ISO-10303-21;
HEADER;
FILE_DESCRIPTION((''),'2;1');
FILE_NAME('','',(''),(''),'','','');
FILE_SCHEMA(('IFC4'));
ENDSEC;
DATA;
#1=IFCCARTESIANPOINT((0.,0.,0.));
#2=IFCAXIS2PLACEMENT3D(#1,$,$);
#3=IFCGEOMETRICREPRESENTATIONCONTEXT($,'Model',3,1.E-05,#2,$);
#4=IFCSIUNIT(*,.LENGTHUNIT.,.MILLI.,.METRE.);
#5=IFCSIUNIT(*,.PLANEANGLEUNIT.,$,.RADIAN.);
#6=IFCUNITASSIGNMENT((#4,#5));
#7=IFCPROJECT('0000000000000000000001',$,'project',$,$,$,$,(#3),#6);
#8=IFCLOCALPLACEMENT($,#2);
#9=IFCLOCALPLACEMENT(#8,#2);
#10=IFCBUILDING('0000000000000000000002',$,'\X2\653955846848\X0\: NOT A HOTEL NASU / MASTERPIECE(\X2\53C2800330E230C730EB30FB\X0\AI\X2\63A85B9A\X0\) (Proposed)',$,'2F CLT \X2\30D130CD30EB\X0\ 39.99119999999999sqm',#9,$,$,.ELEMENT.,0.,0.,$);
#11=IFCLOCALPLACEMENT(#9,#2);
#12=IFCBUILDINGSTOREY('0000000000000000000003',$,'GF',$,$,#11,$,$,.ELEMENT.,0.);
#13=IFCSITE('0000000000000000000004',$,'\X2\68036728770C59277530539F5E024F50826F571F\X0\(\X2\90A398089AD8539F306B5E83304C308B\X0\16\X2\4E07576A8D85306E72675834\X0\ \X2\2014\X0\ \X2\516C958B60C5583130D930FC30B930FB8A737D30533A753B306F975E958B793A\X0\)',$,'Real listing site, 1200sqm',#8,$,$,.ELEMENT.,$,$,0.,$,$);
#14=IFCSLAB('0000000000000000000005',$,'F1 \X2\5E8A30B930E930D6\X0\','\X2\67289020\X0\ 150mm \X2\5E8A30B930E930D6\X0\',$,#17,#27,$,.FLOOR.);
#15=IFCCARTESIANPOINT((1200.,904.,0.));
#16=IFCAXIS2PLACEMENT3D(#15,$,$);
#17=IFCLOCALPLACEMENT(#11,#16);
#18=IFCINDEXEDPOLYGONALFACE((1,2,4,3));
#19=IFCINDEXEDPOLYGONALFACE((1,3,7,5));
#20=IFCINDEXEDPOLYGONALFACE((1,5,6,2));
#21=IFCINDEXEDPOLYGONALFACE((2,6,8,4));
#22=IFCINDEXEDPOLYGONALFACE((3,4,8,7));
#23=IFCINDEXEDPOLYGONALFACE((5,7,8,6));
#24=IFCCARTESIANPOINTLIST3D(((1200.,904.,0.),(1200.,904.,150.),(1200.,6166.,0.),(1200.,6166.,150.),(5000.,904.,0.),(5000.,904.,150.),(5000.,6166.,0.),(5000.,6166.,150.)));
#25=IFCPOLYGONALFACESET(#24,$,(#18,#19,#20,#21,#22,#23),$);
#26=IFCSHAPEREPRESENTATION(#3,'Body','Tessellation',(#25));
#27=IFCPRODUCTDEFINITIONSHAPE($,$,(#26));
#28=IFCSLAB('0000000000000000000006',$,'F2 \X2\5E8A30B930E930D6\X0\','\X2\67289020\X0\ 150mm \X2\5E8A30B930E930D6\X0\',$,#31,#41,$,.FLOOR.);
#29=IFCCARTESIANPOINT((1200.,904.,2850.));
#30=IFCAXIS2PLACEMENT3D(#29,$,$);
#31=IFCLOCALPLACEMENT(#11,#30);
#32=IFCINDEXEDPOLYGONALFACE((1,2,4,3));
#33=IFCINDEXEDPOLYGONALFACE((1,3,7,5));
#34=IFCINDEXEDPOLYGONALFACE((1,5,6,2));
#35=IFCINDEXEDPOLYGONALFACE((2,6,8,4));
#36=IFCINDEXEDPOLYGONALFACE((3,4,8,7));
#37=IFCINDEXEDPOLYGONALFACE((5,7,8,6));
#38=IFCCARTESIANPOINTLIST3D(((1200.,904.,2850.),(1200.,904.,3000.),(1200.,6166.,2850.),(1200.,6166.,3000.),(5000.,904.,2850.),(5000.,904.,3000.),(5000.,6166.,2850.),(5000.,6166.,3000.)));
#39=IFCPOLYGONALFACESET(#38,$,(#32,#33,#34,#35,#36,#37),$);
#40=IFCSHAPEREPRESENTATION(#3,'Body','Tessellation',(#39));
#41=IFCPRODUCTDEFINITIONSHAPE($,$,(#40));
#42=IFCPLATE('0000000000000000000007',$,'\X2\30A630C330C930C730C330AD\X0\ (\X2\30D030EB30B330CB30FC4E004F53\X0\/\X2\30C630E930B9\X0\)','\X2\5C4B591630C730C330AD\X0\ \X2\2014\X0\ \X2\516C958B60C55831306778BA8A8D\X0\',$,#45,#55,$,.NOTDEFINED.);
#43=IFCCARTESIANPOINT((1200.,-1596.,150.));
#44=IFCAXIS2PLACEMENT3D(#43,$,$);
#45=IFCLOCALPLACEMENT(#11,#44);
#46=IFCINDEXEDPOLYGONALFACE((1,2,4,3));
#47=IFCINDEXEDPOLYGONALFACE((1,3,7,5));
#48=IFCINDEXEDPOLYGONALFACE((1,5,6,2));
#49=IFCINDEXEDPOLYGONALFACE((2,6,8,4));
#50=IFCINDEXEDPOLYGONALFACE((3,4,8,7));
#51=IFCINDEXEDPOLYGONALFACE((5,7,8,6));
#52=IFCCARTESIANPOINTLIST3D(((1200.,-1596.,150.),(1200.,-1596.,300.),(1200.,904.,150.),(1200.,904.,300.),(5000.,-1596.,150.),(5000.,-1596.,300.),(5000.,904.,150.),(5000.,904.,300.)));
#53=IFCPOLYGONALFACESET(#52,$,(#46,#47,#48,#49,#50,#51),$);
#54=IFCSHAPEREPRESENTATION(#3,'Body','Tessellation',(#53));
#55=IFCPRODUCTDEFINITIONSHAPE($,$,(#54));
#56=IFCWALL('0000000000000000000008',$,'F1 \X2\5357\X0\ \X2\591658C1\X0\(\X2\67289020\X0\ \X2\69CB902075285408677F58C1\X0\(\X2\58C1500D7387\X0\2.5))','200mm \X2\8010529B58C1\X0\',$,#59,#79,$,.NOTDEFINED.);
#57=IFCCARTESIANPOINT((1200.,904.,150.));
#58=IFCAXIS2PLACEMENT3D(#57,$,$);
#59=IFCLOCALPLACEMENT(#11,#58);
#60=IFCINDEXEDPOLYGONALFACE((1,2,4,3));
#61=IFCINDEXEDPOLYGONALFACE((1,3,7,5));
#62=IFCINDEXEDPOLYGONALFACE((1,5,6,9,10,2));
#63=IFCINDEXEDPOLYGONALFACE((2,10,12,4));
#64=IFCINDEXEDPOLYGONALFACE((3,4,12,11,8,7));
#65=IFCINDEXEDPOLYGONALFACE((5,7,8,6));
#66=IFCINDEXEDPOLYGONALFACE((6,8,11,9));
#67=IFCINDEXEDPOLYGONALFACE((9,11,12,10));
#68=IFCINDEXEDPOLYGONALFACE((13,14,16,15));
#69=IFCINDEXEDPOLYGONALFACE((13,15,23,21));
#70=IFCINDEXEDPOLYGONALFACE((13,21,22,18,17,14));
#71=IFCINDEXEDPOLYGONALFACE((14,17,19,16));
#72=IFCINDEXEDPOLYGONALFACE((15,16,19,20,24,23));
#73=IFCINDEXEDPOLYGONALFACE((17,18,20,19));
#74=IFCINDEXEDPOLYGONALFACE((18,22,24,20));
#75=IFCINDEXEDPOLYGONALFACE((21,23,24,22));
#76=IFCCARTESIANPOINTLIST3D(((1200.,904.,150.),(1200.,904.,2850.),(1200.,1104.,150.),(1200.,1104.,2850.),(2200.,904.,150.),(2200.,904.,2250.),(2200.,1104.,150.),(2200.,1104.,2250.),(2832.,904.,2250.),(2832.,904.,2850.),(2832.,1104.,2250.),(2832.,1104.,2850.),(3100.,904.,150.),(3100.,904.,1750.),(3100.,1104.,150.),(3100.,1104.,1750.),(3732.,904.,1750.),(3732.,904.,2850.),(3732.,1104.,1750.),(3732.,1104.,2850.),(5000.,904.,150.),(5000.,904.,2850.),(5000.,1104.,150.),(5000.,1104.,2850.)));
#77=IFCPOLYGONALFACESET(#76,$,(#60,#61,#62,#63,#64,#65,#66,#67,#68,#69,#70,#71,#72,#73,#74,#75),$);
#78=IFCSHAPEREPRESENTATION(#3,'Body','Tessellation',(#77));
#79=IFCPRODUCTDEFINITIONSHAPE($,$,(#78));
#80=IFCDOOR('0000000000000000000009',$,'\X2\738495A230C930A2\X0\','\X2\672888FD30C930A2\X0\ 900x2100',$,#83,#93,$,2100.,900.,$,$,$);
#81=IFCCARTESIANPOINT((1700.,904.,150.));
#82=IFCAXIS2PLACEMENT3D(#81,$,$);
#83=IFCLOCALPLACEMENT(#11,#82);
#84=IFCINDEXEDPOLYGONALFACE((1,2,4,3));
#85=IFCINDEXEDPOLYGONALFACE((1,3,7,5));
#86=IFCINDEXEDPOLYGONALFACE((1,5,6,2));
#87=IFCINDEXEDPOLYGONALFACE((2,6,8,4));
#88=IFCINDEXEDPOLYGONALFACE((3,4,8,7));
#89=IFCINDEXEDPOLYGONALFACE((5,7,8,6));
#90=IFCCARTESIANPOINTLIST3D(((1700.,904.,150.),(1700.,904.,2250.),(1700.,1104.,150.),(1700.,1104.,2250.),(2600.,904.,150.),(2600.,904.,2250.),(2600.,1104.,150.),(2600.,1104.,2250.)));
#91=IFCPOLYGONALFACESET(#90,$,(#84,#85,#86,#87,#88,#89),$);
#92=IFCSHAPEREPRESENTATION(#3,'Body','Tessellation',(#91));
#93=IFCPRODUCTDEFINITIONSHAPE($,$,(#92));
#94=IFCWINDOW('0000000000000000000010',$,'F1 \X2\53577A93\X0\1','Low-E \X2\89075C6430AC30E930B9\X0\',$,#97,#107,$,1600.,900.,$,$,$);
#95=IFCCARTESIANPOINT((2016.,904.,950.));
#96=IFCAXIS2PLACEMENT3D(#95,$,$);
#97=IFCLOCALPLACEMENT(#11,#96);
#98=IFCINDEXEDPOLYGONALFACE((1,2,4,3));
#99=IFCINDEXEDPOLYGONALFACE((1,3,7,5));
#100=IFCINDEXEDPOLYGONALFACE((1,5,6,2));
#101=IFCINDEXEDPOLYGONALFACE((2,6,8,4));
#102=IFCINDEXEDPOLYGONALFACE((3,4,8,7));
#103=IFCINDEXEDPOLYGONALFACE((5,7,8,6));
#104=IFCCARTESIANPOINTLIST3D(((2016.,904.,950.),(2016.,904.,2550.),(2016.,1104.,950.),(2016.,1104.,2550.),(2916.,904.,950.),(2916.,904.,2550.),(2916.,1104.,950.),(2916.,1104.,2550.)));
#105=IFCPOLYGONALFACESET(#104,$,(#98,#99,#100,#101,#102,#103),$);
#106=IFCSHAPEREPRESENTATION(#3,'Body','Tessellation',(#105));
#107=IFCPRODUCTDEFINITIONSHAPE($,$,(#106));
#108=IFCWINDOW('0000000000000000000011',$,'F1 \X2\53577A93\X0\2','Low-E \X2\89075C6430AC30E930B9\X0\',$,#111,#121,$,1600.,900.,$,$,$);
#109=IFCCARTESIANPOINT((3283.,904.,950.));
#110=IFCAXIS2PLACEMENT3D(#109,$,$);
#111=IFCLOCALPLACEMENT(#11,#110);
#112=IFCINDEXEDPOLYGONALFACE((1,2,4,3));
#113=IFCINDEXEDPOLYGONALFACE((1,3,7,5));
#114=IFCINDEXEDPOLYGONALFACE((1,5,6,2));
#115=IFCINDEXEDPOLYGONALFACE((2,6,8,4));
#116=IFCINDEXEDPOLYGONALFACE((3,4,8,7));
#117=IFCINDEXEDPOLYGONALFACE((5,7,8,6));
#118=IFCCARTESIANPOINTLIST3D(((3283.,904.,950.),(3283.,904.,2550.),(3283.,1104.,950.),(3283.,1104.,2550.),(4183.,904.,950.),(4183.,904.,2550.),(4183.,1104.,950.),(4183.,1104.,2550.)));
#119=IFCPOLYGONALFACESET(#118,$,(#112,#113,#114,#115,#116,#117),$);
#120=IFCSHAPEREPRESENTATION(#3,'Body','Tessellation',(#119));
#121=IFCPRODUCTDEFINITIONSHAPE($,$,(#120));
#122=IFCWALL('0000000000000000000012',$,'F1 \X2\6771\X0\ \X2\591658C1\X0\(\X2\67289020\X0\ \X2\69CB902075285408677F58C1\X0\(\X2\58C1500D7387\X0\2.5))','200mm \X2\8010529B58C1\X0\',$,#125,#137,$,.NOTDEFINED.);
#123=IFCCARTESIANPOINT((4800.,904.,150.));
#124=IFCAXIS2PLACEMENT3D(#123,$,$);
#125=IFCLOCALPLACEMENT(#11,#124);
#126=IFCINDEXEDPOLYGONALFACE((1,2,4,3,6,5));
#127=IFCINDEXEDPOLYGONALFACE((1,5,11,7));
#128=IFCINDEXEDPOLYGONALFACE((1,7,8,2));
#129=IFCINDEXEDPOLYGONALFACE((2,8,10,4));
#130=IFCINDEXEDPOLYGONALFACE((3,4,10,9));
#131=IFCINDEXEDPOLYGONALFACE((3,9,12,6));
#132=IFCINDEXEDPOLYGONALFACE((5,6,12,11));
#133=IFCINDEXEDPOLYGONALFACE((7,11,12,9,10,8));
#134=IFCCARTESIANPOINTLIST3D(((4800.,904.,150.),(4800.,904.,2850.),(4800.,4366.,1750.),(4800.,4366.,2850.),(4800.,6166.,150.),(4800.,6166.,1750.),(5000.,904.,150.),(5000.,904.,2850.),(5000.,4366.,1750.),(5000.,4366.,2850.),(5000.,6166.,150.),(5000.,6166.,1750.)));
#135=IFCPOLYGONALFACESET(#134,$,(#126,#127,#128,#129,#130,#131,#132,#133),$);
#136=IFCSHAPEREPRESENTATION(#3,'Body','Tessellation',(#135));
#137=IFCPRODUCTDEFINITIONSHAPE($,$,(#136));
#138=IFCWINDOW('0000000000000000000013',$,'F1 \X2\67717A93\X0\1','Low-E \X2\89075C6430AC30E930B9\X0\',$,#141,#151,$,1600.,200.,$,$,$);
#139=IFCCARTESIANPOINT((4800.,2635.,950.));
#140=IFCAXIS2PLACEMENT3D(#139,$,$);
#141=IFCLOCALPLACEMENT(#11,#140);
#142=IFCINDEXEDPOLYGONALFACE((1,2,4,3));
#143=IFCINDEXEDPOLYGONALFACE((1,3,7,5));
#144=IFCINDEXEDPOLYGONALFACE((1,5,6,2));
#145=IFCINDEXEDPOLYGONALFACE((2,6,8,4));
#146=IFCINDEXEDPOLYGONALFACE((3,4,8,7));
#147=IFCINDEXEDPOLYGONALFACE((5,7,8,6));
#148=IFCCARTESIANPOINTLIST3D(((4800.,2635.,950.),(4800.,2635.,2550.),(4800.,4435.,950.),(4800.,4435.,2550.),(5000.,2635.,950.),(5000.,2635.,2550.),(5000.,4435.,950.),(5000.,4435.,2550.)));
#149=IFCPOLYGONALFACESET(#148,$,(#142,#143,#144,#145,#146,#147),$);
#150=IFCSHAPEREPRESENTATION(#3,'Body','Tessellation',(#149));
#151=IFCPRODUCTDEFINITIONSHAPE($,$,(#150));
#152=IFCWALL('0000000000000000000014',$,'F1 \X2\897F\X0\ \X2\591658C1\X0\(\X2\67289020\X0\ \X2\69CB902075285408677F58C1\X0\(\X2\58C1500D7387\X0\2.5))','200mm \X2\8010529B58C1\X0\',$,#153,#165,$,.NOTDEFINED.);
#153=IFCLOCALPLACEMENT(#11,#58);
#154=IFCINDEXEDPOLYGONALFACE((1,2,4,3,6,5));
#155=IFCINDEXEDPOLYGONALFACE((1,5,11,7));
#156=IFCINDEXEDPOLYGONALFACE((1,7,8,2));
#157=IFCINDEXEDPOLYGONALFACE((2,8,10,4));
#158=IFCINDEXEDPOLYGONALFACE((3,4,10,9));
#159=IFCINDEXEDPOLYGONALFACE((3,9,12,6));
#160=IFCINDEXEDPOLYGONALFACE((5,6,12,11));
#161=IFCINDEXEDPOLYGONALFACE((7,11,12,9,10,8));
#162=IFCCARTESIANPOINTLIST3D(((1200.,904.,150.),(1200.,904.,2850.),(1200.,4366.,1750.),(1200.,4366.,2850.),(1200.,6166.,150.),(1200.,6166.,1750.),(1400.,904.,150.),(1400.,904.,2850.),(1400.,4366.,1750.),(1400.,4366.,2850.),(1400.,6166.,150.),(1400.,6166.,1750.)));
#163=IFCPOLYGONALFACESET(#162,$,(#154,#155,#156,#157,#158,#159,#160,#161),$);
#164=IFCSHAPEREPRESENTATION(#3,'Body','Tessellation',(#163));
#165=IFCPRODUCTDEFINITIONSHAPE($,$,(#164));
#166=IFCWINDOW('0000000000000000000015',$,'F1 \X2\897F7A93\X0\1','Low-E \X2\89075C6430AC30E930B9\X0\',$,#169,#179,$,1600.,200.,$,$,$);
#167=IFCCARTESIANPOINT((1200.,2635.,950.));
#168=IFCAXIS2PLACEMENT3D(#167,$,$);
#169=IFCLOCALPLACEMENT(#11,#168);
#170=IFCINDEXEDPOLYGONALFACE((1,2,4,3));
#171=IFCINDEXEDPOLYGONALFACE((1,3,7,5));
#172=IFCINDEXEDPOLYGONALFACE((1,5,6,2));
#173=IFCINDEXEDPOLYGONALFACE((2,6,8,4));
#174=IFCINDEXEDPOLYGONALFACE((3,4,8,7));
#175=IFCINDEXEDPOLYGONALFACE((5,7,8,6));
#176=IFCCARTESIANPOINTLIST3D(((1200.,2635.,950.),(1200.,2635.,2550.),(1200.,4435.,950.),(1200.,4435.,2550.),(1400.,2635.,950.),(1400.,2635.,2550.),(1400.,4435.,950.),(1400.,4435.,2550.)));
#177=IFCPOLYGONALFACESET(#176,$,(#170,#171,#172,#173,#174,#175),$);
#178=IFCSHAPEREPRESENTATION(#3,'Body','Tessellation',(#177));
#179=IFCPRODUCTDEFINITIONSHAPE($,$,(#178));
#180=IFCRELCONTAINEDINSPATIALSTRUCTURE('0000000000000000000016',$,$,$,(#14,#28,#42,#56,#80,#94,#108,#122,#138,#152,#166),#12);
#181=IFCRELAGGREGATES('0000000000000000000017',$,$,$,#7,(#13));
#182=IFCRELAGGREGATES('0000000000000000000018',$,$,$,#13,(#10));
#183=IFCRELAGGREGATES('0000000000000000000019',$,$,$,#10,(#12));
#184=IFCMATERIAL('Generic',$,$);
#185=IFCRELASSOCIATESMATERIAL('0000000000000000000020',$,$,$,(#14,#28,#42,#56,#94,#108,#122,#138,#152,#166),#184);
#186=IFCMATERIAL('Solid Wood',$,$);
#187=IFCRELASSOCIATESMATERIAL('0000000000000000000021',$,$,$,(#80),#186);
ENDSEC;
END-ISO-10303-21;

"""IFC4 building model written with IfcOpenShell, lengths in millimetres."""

from ifc_helpers import new_model, si_unit, frame, frame_2d, origin, place, context, project, spatial, rectangle, extrude, material, element, fill, save


model = new_model("IFC4")

# Units and contexts
model_context = context("Model", 3, precision=1e-05, world=origin())
ifc_project = project(units=[si_unit("LENGTHUNIT", "METRE", prefix="MILLI"), si_unit("PLANEANGLEUNIT", "RADIAN")], contexts=[model_context])

# Site, building, storey
site_placement = place(None, origin())
site = spatial("IfcSite", under=ifc_project, at=site_placement, Name="栃木県大田原市佐良土(那須高原に広がる16万坪超の牧場 — 公開情報ベース・詳細区画は非開示)", ObjectType="Real listing site, 1200sqm", CompositionType="ELEMENT", RefElevation=0.0)
building_placement = place(site_placement, origin())
building = spatial("IfcBuilding", under=site, at=building_placement, Name="改善案: NOT A HOTEL NASU / MASTERPIECE(参考モデル・AI推定) (Proposed)", ObjectType="2F CLT パネル 39.99119999999999sqm", CompositionType="ELEMENT", ElevationOfRefHeight=0.0, ElevationOfTerrain=0.0)
storey_placement = place(building_placement, origin())
storey = spatial("IfcBuildingStorey", under=building, at=storey_placement, Name="GF", CompositionType="ELEMENT", Elevation=0.0)

# Slabs
ifc_material_1 = material(Name="Generic")
slab_1_placement = place(storey_placement, frame((1200.0, 904.0, 0.0)))
element("IfcSlab", 1, at=slab_1_placement, inside=storey, material=ifc_material_1, Name="F1 床スラブ", Description="木造 150mm 床スラブ", PredefinedType="FLOOR", context=model_context, shape_type="SweptSolid", body=[
    extrude(rectangle(XDim=3800.0, YDim=5262.0, at=frame_2d((1900.0, 2631.0))), frame((1200.0, 904.0, 0.0)), (0.0, 0.0, 1.0), 150.0),
])
slab_2_placement = place(storey_placement, frame((1200.0, 904.0, 2850.0)))
element("IfcSlab", 2, at=slab_2_placement, inside=storey, material=ifc_material_1, Name="F2 床スラブ", Description="木造 150mm 床スラブ", PredefinedType="FLOOR", context=model_context, shape_type="SweptSolid", body=[
    extrude(rectangle(XDim=3800.0, YDim=5262.0, at=frame_2d((1900.0, 2631.0))), frame((1200.0, 904.0, 2850.0)), (0.0, 0.0, 1.0), 150.0),
])

# Plate
plate_placement = place(storey_placement, frame((1200.0, -1596.0, 150.0)))
element("IfcPlate", 3, at=plate_placement, inside=storey, material=ifc_material_1, Name="ウッドデッキ (バルコニー一体/テラス)", Description="屋外デッキ — 公開情報で確認", PredefinedType="NOTDEFINED", context=model_context, shape_type="SweptSolid", body=[
    extrude(rectangle(XDim=3800.0, YDim=2500.0, at=frame_2d((1900.0, 1250.0))), frame((1200.0, -1596.0, 150.0)), (0.0, 0.0, 1.0), 150.0),
])

# Wall, openings, door, windows
wall_1_placement = place(storey_placement, frame((1200.0, 904.0, 150.0)))
wall_1 = element("IfcWall", 4, at=wall_1_placement, inside=storey, material=ifc_material_1, Name="F1 南 外壁(木造 構造用合板壁(壁倍率2.5))", Description="200mm 耐力壁", PredefinedType="NOTDEFINED", context=model_context, shape_type="SweptSolid", body=[
    extrude(rectangle(XDim=3800.0, YDim=200.0, at=frame_2d((1900.0, 100.0))), frame((1200.0, 904.0, 150.0)), (0.0, 0.0, 1.0), 2700.0),
])
opening_1_placement = place(storey_placement, frame((1700.0, 904.0, 150.0)))
opening_1 = element("IfcOpeningElement", 5, at=opening_1_placement, cuts=wall_1, PredefinedType="NOTDEFINED", context=model_context, shape_type="SweptSolid", body=[
    extrude(rectangle(XDim=900.0, YDim=200.0, at=frame_2d((450.0, 100.0))), frame((1700.0, 904.0, 150.0)), (0.0, 0.0, 1.0), 2100.0),
])
opening_2_placement = place(storey_placement, frame((2016.0, 904.0, 950.0)))
opening_2 = element("IfcOpeningElement", 6, at=opening_2_placement, cuts=wall_1, PredefinedType="NOTDEFINED", context=model_context, shape_type="SweptSolid", body=[
    extrude(rectangle(XDim=900.0, YDim=200.0, at=frame_2d((450.0, 100.0))), frame((2016.0, 904.0, 950.0)), (0.0, 0.0, 1.0), 1600.0),
])
opening_3_placement = place(storey_placement, frame((3283.0, 904.0, 950.0)))
opening_3 = element("IfcOpeningElement", 7, at=opening_3_placement, cuts=wall_1, PredefinedType="NOTDEFINED", context=model_context, shape_type="SweptSolid", body=[
    extrude(rectangle(XDim=900.0, YDim=200.0, at=frame_2d((450.0, 100.0))), frame((3283.0, 904.0, 950.0)), (0.0, 0.0, 1.0), 1600.0),
])
ifc_material_2 = material(Name="Solid Wood")
door_placement = place(storey_placement, frame((1700.0, 904.0, 150.0)))
door = element("IfcDoor", 8, at=door_placement, inside=storey, material=ifc_material_2, Name="玄関ドア", Description="木製ドア 900x2100", OverallHeight=2100.0, OverallWidth=900.0, context=model_context, shape_type="SweptSolid", body=[
    extrude(rectangle(XDim=900.0, YDim=200.0, at=frame_2d((450.0, 100.0))), frame((1700.0, 904.0, 150.0)), (0.0, 0.0, 1.0), 2100.0),
])
fill(opening_1, door)
window_1_placement = place(storey_placement, frame((2016.0, 904.0, 950.0)))
window_1 = element("IfcWindow", 9, at=window_1_placement, inside=storey, material=ifc_material_1, Name="F1 南窓1", Description="Low-E 複層ガラス", OverallHeight=1600.0, OverallWidth=900.0, context=model_context, shape_type="SweptSolid", body=[
    extrude(rectangle(XDim=900.0, YDim=200.0, at=frame_2d((450.0, 100.0))), frame((2016.0, 904.0, 950.0)), (0.0, 0.0, 1.0), 1600.0),
])
fill(opening_2, window_1)
window_2_placement = place(storey_placement, frame((3283.0, 904.0, 950.0)))
window_2 = element("IfcWindow", 10, at=window_2_placement, inside=storey, material=ifc_material_1, Name="F1 南窓2", Description="Low-E 複層ガラス", OverallHeight=1600.0, OverallWidth=900.0, context=model_context, shape_type="SweptSolid", body=[
    extrude(rectangle(XDim=900.0, YDim=200.0, at=frame_2d((450.0, 100.0))), frame((3283.0, 904.0, 950.0)), (0.0, 0.0, 1.0), 1600.0),
])
fill(opening_3, window_2)

# Walls, openings, windows
wall_2_placement = place(storey_placement, frame((4800.0, 904.0, 150.0)))
wall_2 = element("IfcWall", 11, at=wall_2_placement, inside=storey, material=ifc_material_1, Name="F1 東 外壁(木造 構造用合板壁(壁倍率2.5))", Description="200mm 耐力壁", PredefinedType="NOTDEFINED", context=model_context, shape_type="SweptSolid", body=[
    extrude(rectangle(XDim=200.0, YDim=5262.0, at=frame_2d((100.0, 2631.0))), frame((4800.0, 904.0, 150.0)), (0.0, 0.0, 1.0), 2700.0),
])
opening_4_placement = place(storey_placement, frame((4800.0, 2635.0, 950.0)))
opening_4 = element("IfcOpeningElement", 12, at=opening_4_placement, cuts=wall_2, PredefinedType="NOTDEFINED", context=model_context, shape_type="SweptSolid", body=[
    extrude(rectangle(XDim=200.0, YDim=1800.0, at=frame_2d((100.0, 900.0))), frame((4800.0, 2635.0, 950.0)), (0.0, 0.0, 1.0), 1600.0),
])
window_3_placement = place(storey_placement, frame((4800.0, 2635.0, 950.0)))
window_3 = element("IfcWindow", 13, at=window_3_placement, inside=storey, material=ifc_material_1, Name="F1 東窓1", Description="Low-E 複層ガラス", OverallHeight=1600.0, OverallWidth=200.0, context=model_context, shape_type="SweptSolid", body=[
    extrude(rectangle(XDim=200.0, YDim=1800.0, at=frame_2d((100.0, 900.0))), frame((4800.0, 2635.0, 950.0)), (0.0, 0.0, 1.0), 1600.0),
])
fill(opening_4, window_3)
wall_3_placement = place(storey_placement, frame((1200.0, 904.0, 150.0)))
wall_3 = element("IfcWall", 14, at=wall_3_placement, inside=storey, material=ifc_material_1, Name="F1 西 外壁(木造 構造用合板壁(壁倍率2.5))", Description="200mm 耐力壁", PredefinedType="NOTDEFINED", context=model_context, shape_type="SweptSolid", body=[
    extrude(rectangle(XDim=200.0, YDim=5262.0, at=frame_2d((100.0, 2631.0))), frame((1200.0, 904.0, 150.0)), (0.0, 0.0, 1.0), 2700.0),
])
opening_5_placement = place(storey_placement, frame((1200.0, 2635.0, 950.0)))
opening_5 = element("IfcOpeningElement", 15, at=opening_5_placement, cuts=wall_3, PredefinedType="NOTDEFINED", context=model_context, shape_type="SweptSolid", body=[
    extrude(rectangle(XDim=200.0, YDim=1800.0, at=frame_2d((100.0, 900.0))), frame((1200.0, 2635.0, 950.0)), (0.0, 0.0, 1.0), 1600.0),
])
window_4_placement = place(storey_placement, frame((1200.0, 2635.0, 950.0)))
window_4 = element("IfcWindow", 16, at=window_4_placement, inside=storey, material=ifc_material_1, Name="F1 西窓1", Description="Low-E 複層ガラス", OverallHeight=1600.0, OverallWidth=200.0, context=model_context, shape_type="SweptSolid", body=[
    extrude(rectangle(XDim=200.0, YDim=1800.0, at=frame_2d((100.0, 900.0))), frame((1200.0, 2635.0, 950.0)), (0.0, 0.0, 1.0), 1600.0),
])
fill(opening_5, window_4)

save(model, "model.ifc")
